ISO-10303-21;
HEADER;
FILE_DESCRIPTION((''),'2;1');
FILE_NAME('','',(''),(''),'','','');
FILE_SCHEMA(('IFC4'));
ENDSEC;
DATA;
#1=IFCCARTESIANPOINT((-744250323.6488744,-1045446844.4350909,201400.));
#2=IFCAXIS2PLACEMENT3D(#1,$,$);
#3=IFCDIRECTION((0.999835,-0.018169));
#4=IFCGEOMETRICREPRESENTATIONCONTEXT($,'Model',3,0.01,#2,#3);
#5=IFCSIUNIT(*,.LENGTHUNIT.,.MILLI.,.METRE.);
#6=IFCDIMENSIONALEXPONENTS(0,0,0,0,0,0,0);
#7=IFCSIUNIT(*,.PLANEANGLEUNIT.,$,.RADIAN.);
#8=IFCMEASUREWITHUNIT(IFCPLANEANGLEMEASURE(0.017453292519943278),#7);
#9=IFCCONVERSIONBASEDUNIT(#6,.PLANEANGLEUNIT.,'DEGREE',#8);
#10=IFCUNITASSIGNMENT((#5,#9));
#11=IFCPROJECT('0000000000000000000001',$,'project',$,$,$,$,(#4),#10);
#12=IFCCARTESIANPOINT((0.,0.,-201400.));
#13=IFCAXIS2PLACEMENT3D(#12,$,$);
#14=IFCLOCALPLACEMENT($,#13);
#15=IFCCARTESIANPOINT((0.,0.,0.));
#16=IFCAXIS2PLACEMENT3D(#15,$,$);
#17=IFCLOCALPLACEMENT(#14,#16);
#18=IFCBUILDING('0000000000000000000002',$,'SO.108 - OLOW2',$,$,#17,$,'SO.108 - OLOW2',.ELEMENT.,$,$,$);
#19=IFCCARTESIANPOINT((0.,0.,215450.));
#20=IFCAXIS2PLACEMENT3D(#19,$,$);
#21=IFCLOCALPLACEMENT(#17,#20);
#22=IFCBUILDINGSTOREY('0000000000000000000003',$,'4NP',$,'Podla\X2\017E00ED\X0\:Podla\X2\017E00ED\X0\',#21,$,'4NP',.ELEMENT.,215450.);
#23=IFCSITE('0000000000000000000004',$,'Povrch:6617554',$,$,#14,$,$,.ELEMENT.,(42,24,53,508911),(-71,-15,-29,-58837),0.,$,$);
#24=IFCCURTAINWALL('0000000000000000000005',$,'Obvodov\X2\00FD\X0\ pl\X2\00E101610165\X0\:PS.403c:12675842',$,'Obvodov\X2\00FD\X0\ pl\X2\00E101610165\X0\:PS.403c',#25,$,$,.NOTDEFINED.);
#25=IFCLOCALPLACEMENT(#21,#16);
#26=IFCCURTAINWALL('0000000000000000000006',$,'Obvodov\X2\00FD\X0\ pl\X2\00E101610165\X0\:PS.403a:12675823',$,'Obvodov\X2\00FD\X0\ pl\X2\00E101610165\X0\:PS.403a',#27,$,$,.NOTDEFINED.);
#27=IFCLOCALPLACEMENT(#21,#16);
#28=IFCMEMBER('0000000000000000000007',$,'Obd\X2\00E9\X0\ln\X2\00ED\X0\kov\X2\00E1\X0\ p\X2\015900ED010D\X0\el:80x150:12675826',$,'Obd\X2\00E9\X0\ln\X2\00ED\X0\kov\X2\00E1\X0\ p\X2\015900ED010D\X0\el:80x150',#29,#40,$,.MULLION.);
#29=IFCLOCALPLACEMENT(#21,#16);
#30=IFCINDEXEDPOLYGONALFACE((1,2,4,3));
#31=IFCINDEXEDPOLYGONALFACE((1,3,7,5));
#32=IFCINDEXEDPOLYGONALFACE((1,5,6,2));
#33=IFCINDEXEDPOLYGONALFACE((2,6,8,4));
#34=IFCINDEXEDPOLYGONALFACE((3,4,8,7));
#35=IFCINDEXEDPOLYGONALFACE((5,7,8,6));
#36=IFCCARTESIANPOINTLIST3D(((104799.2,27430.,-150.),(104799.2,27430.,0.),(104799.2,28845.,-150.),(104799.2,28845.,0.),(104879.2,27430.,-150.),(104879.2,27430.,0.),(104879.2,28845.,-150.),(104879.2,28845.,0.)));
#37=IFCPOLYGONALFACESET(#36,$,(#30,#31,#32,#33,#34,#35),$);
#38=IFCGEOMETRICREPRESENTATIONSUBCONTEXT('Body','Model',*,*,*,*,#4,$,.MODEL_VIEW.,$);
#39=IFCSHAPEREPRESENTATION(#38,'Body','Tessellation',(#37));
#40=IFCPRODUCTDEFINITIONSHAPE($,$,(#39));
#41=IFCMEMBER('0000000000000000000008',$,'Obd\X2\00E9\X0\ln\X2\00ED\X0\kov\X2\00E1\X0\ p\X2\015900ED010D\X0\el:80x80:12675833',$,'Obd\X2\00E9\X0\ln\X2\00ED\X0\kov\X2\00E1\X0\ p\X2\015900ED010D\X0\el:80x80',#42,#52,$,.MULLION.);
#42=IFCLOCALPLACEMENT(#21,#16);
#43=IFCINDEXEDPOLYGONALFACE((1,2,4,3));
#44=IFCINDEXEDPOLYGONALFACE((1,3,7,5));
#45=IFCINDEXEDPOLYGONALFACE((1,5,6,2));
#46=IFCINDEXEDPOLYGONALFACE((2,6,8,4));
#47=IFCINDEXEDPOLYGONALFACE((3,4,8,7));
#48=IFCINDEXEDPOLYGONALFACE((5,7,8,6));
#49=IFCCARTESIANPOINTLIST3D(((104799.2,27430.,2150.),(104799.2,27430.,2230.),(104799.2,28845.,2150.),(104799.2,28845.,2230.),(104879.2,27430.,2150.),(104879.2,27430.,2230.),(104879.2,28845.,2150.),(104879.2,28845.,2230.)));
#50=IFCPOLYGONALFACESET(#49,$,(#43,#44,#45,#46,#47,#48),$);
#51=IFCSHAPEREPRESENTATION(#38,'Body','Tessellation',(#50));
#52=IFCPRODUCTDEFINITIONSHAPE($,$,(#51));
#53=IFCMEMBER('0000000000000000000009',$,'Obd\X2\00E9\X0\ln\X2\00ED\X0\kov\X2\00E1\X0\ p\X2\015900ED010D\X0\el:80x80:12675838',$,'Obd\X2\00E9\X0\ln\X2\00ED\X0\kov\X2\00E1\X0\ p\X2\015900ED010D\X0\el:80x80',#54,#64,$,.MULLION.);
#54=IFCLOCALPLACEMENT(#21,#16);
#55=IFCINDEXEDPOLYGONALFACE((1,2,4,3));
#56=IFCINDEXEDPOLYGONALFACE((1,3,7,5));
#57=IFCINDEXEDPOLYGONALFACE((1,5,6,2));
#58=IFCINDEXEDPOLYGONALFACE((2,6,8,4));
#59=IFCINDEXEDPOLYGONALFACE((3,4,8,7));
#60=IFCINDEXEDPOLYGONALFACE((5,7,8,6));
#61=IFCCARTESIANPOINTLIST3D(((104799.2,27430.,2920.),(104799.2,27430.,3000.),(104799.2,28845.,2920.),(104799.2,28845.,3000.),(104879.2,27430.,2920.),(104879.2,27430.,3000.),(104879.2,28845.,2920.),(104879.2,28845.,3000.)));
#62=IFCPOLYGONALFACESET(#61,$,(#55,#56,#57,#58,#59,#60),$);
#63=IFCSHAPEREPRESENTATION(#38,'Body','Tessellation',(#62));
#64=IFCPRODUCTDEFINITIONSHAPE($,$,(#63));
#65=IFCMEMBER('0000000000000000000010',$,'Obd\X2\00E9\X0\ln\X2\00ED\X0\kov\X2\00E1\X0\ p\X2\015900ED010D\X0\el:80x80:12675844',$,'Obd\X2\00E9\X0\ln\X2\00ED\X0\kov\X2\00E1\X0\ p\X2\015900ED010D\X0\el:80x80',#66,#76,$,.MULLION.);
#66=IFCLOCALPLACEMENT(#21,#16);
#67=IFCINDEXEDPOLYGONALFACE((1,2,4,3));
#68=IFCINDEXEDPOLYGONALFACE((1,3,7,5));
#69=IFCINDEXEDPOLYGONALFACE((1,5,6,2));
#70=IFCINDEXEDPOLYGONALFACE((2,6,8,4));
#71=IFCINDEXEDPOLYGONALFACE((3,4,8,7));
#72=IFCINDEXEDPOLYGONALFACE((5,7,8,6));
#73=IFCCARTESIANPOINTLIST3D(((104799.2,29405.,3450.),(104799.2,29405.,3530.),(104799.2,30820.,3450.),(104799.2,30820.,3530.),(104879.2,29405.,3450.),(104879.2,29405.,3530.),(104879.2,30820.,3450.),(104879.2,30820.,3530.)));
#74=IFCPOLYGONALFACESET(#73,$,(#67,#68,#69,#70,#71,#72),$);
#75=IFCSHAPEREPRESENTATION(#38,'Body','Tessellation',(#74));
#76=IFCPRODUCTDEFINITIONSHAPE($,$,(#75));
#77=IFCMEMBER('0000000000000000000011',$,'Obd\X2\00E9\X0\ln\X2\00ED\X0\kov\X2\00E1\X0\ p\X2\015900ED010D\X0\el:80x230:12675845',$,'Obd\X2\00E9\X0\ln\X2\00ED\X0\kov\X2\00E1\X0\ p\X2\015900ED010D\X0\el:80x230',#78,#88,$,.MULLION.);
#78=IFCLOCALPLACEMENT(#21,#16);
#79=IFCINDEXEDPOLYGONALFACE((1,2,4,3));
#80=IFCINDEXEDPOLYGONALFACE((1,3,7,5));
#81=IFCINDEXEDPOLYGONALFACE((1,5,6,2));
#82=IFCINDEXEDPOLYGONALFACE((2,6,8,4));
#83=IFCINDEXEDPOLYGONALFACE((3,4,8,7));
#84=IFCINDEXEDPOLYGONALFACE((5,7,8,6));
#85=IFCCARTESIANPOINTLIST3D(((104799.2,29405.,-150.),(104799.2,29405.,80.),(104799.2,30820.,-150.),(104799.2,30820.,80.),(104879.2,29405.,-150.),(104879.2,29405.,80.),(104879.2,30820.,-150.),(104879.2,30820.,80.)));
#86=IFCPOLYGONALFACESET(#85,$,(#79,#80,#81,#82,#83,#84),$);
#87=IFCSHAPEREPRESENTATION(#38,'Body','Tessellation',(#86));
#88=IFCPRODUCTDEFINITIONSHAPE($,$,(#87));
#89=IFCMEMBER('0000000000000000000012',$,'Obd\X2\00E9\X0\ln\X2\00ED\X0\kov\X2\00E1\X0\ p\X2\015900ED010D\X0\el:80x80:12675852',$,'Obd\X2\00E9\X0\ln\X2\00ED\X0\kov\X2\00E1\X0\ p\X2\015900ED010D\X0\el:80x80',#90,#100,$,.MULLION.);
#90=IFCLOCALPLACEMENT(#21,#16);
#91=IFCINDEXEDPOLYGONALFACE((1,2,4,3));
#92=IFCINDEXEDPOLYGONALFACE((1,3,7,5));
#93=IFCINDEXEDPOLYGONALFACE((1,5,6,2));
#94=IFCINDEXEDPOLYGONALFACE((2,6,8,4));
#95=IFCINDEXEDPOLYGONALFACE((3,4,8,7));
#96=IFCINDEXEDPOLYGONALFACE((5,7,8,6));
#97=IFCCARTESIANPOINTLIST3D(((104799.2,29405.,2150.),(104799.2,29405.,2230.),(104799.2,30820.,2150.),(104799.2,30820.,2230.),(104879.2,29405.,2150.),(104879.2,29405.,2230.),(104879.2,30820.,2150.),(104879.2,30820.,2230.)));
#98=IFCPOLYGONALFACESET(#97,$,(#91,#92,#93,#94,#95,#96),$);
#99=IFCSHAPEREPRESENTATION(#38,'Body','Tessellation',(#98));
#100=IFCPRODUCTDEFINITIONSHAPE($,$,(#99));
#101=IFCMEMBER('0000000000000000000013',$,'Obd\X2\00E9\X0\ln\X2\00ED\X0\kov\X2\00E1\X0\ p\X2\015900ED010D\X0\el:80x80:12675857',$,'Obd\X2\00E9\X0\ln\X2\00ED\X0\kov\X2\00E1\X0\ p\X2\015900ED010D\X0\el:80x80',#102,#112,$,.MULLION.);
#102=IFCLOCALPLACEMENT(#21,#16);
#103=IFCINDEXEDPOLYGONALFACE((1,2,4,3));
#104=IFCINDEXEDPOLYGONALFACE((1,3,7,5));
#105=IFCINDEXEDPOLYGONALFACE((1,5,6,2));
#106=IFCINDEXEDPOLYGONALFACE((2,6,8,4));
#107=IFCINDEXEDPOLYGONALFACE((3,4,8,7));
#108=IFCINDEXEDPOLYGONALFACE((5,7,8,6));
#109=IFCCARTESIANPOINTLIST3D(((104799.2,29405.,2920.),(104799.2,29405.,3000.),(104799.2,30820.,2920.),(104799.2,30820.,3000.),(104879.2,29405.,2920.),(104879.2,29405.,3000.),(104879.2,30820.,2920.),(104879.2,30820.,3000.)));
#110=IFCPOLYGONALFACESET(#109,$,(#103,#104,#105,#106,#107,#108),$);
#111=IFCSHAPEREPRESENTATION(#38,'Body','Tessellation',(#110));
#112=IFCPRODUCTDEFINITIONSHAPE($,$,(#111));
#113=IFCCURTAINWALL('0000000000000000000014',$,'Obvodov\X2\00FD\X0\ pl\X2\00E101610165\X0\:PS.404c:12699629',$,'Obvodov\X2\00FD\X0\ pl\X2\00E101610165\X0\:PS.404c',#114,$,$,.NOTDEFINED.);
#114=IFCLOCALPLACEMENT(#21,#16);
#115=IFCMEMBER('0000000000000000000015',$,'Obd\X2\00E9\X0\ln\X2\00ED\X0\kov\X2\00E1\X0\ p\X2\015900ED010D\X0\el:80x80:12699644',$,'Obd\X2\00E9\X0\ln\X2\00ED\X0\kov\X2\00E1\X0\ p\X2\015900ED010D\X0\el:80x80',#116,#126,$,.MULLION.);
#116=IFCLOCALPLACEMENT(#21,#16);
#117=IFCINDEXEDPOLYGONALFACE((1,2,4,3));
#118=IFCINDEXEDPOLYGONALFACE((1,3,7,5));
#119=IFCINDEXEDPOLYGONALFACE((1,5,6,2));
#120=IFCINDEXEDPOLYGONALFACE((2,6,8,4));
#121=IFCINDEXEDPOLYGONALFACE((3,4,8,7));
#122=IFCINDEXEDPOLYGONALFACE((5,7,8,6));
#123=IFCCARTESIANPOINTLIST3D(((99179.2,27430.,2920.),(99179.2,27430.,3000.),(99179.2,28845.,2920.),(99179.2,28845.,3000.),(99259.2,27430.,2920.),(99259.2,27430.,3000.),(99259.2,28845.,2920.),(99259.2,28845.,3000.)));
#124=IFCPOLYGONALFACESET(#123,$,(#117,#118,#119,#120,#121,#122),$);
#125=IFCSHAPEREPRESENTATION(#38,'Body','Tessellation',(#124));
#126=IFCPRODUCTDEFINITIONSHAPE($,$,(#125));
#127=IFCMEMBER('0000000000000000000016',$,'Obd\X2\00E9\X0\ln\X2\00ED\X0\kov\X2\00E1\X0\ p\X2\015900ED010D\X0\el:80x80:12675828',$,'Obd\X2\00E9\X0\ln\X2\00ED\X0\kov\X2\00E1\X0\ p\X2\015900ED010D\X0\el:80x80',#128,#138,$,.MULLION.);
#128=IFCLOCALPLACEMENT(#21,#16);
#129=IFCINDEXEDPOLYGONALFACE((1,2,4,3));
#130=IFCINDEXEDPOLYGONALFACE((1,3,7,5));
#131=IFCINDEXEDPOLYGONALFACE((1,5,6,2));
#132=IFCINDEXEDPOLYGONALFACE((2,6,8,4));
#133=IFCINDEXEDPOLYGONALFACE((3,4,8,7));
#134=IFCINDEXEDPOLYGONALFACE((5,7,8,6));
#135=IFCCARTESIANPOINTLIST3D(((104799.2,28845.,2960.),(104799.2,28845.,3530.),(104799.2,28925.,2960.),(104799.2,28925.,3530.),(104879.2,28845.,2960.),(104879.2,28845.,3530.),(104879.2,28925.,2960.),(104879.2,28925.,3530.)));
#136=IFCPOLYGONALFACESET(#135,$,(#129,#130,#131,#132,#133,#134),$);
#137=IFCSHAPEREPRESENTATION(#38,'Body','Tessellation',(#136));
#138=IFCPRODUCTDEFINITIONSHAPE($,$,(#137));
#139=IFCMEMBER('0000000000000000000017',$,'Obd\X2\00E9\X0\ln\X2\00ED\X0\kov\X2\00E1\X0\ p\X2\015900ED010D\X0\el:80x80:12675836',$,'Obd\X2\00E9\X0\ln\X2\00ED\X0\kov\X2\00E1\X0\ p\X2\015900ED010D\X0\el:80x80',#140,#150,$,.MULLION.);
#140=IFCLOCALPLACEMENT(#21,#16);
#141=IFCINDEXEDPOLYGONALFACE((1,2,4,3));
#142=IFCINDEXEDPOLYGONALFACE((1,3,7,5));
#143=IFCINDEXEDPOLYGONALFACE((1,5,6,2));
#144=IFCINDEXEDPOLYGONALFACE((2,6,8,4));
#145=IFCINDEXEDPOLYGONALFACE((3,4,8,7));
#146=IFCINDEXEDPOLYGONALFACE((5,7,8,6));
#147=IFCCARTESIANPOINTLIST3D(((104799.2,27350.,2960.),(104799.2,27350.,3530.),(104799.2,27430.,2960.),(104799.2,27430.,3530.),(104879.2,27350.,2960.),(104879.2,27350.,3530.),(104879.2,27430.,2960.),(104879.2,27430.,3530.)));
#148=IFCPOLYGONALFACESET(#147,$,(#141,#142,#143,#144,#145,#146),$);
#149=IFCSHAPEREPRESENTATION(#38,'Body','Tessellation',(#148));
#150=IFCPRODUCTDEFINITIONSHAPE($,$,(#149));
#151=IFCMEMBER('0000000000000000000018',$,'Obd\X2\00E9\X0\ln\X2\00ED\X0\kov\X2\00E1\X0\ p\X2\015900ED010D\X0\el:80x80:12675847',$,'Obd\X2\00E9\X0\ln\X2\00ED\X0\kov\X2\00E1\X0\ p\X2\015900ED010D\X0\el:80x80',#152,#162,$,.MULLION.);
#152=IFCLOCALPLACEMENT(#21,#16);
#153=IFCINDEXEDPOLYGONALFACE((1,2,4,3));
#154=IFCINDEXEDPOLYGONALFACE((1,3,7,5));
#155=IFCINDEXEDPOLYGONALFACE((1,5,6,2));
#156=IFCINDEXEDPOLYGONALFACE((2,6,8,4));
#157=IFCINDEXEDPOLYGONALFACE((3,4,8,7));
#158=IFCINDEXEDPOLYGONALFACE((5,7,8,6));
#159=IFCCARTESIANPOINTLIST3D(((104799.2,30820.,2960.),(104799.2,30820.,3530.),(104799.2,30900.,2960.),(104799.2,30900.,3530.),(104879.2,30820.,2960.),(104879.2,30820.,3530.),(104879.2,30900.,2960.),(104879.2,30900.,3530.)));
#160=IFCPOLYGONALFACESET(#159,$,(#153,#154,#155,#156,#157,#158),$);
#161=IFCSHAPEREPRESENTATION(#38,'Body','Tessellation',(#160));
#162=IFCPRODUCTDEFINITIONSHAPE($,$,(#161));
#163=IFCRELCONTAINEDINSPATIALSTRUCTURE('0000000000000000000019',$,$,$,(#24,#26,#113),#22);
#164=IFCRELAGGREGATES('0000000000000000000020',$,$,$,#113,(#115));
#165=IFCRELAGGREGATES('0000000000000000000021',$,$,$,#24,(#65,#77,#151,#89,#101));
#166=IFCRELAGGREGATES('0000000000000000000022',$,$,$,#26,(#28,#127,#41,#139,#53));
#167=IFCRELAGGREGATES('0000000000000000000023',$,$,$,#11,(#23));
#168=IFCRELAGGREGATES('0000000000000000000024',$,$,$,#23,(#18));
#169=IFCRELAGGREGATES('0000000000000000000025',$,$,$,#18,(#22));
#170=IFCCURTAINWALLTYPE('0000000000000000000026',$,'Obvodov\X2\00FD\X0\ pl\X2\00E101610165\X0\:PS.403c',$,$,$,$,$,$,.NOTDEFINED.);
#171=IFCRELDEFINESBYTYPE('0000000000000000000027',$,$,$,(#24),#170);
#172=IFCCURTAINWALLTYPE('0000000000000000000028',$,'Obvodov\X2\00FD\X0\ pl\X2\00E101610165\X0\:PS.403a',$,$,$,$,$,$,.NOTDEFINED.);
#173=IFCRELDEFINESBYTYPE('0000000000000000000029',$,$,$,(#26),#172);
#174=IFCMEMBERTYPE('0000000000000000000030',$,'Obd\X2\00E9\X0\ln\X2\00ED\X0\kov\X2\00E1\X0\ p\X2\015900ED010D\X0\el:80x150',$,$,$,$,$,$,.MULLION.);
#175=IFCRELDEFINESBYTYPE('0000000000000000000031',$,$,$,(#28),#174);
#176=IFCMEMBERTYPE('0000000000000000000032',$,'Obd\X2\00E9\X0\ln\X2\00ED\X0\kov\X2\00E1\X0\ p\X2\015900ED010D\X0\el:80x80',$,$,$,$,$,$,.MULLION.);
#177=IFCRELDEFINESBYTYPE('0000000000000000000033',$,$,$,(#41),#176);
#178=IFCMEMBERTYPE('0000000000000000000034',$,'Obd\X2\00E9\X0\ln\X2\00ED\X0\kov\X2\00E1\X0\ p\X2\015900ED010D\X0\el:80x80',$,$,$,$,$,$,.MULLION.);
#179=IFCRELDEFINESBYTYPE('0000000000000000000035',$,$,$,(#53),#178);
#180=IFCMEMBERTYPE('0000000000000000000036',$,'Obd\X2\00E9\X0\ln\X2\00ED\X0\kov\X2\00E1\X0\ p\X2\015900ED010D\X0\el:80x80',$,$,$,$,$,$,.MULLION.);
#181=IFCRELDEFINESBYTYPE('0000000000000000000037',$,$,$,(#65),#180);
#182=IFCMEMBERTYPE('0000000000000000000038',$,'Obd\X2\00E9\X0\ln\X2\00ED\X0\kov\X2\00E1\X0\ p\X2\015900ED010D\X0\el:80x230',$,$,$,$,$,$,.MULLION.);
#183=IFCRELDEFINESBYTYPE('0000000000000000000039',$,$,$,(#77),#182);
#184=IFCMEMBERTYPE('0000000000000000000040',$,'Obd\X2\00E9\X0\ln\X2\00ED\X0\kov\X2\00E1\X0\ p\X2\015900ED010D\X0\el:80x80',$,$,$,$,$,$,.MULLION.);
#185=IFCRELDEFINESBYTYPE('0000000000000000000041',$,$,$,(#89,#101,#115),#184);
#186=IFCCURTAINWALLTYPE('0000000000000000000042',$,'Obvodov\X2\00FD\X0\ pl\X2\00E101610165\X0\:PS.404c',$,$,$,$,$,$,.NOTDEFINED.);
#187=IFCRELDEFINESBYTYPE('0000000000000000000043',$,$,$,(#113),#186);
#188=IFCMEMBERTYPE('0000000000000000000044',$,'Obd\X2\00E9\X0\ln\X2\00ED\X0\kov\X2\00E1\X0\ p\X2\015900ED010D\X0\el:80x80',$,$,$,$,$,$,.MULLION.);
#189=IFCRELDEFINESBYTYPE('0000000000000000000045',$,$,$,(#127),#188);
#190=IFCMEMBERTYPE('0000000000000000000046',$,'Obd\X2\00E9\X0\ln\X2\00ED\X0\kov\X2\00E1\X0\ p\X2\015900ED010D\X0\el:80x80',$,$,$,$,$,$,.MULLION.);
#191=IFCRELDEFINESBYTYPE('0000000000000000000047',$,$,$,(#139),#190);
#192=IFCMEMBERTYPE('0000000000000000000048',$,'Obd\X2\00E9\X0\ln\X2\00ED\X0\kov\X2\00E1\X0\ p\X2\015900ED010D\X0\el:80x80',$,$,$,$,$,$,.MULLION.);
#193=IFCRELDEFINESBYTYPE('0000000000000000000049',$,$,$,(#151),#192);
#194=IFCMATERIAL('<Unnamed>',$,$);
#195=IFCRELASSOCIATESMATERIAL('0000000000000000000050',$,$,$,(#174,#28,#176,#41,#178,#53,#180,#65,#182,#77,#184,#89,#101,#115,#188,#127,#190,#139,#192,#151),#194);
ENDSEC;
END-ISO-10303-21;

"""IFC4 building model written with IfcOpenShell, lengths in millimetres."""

from ifc_helpers import new_model, entity, si_unit, converted_unit, direction, frame, origin, place, context, subcontext, project, spatial, indexed_curve, outline, extrude, source, transform, mapped, material, type_object, type_shapes, element, aggregate, save


model = new_model("IFC4")

# Units and contexts
model_context = context("Model", 3, precision=0.01, world=frame((-744250323.6488744, -1045446844.4350909, 201400.0)), true_north=direction((0.999835, -0.018169)))
body_context = subcontext(model_context, "Body", "Model", "MODEL_VIEW")
ifc_project = project(units=[si_unit("LENGTHUNIT", "METRE", prefix="MILLI"), converted_unit("PLANEANGLEUNIT", "DEGREE", entity("IfcPlaneAngleMeasure", 0.017453292519943278), si_unit("PLANEANGLEUNIT", "RADIAN"), dimensions=[0, 0, 0, 0, 0, 0, 0])], contexts=[model_context])

# Site, building, storey
site_placement = place(None, frame((0.0, 0.0, -201400.0)))
site = spatial("IfcSite", under=ifc_project, at=site_placement, Name="Povrch:6617554", CompositionType="ELEMENT", RefLatitude=(42, 24, 53, 508911), RefLongitude=(-71, -15, -29, -58837), RefElevation=0.0)
building_placement = place(site_placement, origin())
building = spatial("IfcBuilding", under=site, at=building_placement, Name="SO.108 - OLOW2", LongName="SO.108 - OLOW2", CompositionType="ELEMENT")
storey_placement = place(building_placement, frame((0.0, 0.0, 215450.0)))
storey = spatial("IfcBuildingStorey", under=building, at=storey_placement, Name="4NP", ObjectType="Podlaží:Podlaží", LongName="4NP", CompositionType="ELEMENT", Elevation=215450.0)

# Curtain wall
curtain_wall_type_1 = type_object("IfcCurtainWallType", Name="Obvodový plášť:PS.403c", PredefinedType="NOTDEFINED")
curtain_wall_1_placement = place(storey_placement, frame((0.0, 0.0, -215450.0)))
curtain_wall_1 = element("IfcCurtainWall", 1, at=curtain_wall_1_placement, inside=storey, type_object=curtain_wall_type_1, Name="Obvodový plášť:PS.403c:12675842", ObjectType="Obvodový plášť:PS.403c", PredefinedType="NOTDEFINED")
ifc_material_1 = material(Name="<Unnamed>")

# Curtain wall, members
curtain_wall_type_2 = type_object("IfcCurtainWallType", Name="Obvodový plášť:PS.403a", PredefinedType="NOTDEFINED")
curtain_wall_2_placement = place(storey_placement, frame((0.0, 0.0, -215450.0)))
curtain_wall_2 = element("IfcCurtainWall", 2, at=curtain_wall_2_placement, inside=storey, type_object=curtain_wall_type_2, Name="Obvodový plášť:PS.403a:12675823", ObjectType="Obvodový plášť:PS.403a", PredefinedType="NOTDEFINED")
member_type_1 = type_object("IfcMemberType", Name="Obdélníková příčel:80x150", PredefinedType="MULLION", material=ifc_material_1)
shared_shape_1 = source(origin(), body_context, "Body", "SweptSolid", [
    extrude(outline(indexed_curve([(-75.0, -40.0), (75.0, -40.0), (75.0, 40.0), (-75.0, 40.0), (-75.0, -40.0)], self_intersect=False)), frame((-75.0, 0.0, -1415.0), z_axis=(0.0, 0.0, 1.0), x_axis=(-1.0, 0.0, 0.0)), (0.0, 0.0, 1.0), 1415.0),
])
type_shapes(member_type_1, [shared_shape_1])
member_1_placement = place(curtain_wall_2_placement, frame((104839.2, 28845.0, 215300.0), z_axis=(0.0, 1.0, 0.0), x_axis=(0.0, 0.0, -1.0)))
member_1 = element("IfcMember", 3, at=member_1_placement, type_object=member_type_1, material=ifc_material_1, Name="Obdélníková příčel:80x150:12675826", ObjectType="Obdélníková příčel:80x150", PredefinedType="MULLION", context=body_context, shape_type="MappedRepresentation", body=[
    mapped(shared_shape_1, transform((0.0, 0.0, 0.0), scale=1.0)),
])
member_type_2 = type_object("IfcMemberType", Name="Obdélníková příčel:80x80", PredefinedType="MULLION", material=ifc_material_1)
shared_shape_2 = source(origin(), body_context, "Body", "SweptSolid", [
    extrude(outline(indexed_curve([(-40.0, -40.0), (40.0, -40.0), (40.0, 40.0), (-40.0, 40.0), (-40.0, -40.0)], self_intersect=False)), frame((0.0, 0.0, -1415.0), z_axis=(0.0, 0.0, 1.0), x_axis=(-1.0, 0.0, 0.0)), (0.0, 0.0, 1.0), 1415.0),
])
type_shapes(member_type_2, [shared_shape_2])
member_2_placement = place(curtain_wall_2_placement, frame((104839.2, 27430.0, 217640.0), z_axis=(0.0, -1.0, 0.0), x_axis=(0.0, 0.0, 1.0)))
member_2 = element("IfcMember", 4, at=member_2_placement, type_object=member_type_2, material=ifc_material_1, Name="Obdélníková příčel:80x80:12675833", ObjectType="Obdélníková příčel:80x80", PredefinedType="MULLION", context=body_context, shape_type="MappedRepresentation", body=[
    mapped(shared_shape_2, transform((0.0, 0.0, 0.0), scale=1.0)),
])
member_type_3 = type_object("IfcMemberType", Name="Obdélníková příčel:80x80", PredefinedType="MULLION", material=ifc_material_1)
shared_shape_3 = source(origin(), body_context, "Body", "SweptSolid", [
    extrude(outline(indexed_curve([(-40.0, -40.0), (40.0, -40.0), (40.0, 40.0), (-40.0, 40.0), (-40.0, -40.0)], self_intersect=False)), frame((0.0, 0.0, -1415.0), z_axis=(0.0, 0.0, 1.0), x_axis=(-1.0, 0.0, 0.0)), (0.0, 0.0, 1.0), 1415.0),
])
type_shapes(member_type_3, [shared_shape_3])
member_3_placement = place(curtain_wall_2_placement, frame((104839.2, 27430.0, 218410.0), z_axis=(0.0, -1.0, 0.0), x_axis=(0.0, 0.0, 1.0)))
member_3 = element("IfcMember", 5, at=member_3_placement, type_object=member_type_3, material=ifc_material_1, Name="Obdélníková příčel:80x80:12675838", ObjectType="Obdélníková příčel:80x80", PredefinedType="MULLION", context=body_context, shape_type="MappedRepresentation", body=[
    mapped(shared_shape_3, transform((0.0, 0.0, 0.0), scale=1.0)),
])

# Members
member_type_4 = type_object("IfcMemberType", Name="Obdélníková příčel:80x80", PredefinedType="MULLION", material=ifc_material_1)
shared_shape_4 = source(origin(), body_context, "Body", "SweptSolid", [
    extrude(outline(indexed_curve([(-40.0, -40.0), (40.0, -40.0), (40.0, 40.0), (-40.0, 40.0), (-40.0, -40.0)], self_intersect=False)), frame((-40.0, 0.0, -1415.0), z_axis=(0.0, 0.0, 1.0), x_axis=(-1.0, 0.0, 0.0)), (0.0, 0.0, 1.0), 1415.0),
])
type_shapes(member_type_4, [shared_shape_4])
member_4_placement = place(curtain_wall_1_placement, frame((104839.2, 29405.0, 218980.0), z_axis=(0.0, -1.0, 0.0), x_axis=(0.0, 0.0, 1.0)))
member_4 = element("IfcMember", 6, at=member_4_placement, type_object=member_type_4, material=ifc_material_1, Name="Obdélníková příčel:80x80:12675844", ObjectType="Obdélníková příčel:80x80", PredefinedType="MULLION", context=body_context, shape_type="MappedRepresentation", body=[
    mapped(shared_shape_4, transform((0.0, 0.0, 0.0), scale=1.0)),
])
member_type_5 = type_object("IfcMemberType", Name="Obdélníková příčel:80x230", PredefinedType="MULLION", material=ifc_material_1)
shared_shape_5 = source(origin(), body_context, "Body", "SweptSolid", [
    extrude(outline(indexed_curve([(-115.0, -40.0), (115.0, -40.0), (115.0, 40.0), (-115.0, 40.0), (-115.0, -40.0)], self_intersect=False)), frame((-115.0, 0.0, -1415.0), z_axis=(0.0, 0.0, 1.0), x_axis=(-1.0, 0.0, 0.0)), (0.0, 0.0, 1.0), 1415.0),
])
type_shapes(member_type_5, [shared_shape_5])
member_5_placement = place(curtain_wall_1_placement, frame((104839.2, 30820.0, 215300.0), z_axis=(0.0, 1.0, 0.0), x_axis=(0.0, 0.0, -1.0)))
member_5 = element("IfcMember", 7, at=member_5_placement, type_object=member_type_5, material=ifc_material_1, Name="Obdélníková příčel:80x230:12675845", ObjectType="Obdélníková příčel:80x230", PredefinedType="MULLION", context=body_context, shape_type="MappedRepresentation", body=[
    mapped(shared_shape_5, transform((0.0, 0.0, 0.0), scale=1.0)),
])
member_type_6 = type_object("IfcMemberType", Name="Obdélníková příčel:80x80", PredefinedType="MULLION", material=ifc_material_1)
shared_shape_6 = source(origin(), body_context, "Body", "SweptSolid", [
    extrude(outline(indexed_curve([(-40.0, -40.0), (40.0, -40.0), (40.0, 40.0), (-40.0, 40.0), (-40.0, -40.0)], self_intersect=False)), frame((0.0, 0.0, -1415.0), z_axis=(0.0, 0.0, 1.0), x_axis=(-1.0, 0.0, 0.0)), (0.0, 0.0, 1.0), 1415.0),
])
type_shapes(member_type_6, [shared_shape_6])
member_6_placement = place(curtain_wall_1_placement, frame((104839.2, 29405.0, 217640.0), z_axis=(0.0, -1.0, 0.0), x_axis=(0.0, 0.0, 1.0)))
member_6 = element("IfcMember", 8, at=member_6_placement, type_object=member_type_6, material=ifc_material_1, Name="Obdélníková příčel:80x80:12675852", ObjectType="Obdélníková příčel:80x80", PredefinedType="MULLION", context=body_context, shape_type="MappedRepresentation", body=[
    mapped(shared_shape_6, transform((0.0, 0.0, 0.0), scale=1.0)),
])
member_7_placement = place(curtain_wall_1_placement, frame((104839.2, 29405.0, 218410.0), z_axis=(0.0, -1.0, 0.0), x_axis=(0.0, 0.0, 1.0)))
member_7 = element("IfcMember", 9, at=member_7_placement, type_object=member_type_6, material=ifc_material_1, Name="Obdélníková příčel:80x80:12675857", ObjectType="Obdélníková příčel:80x80", PredefinedType="MULLION", context=body_context, shape_type="MappedRepresentation", body=[
    mapped(shared_shape_6, transform((0.0, 0.0, 0.0), scale=1.0)),
])

# Curtain wall, member
curtain_wall_type_3 = type_object("IfcCurtainWallType", Name="Obvodový plášť:PS.404c", PredefinedType="NOTDEFINED")
curtain_wall_3_placement = place(storey_placement, frame((0.0, 0.0, -215450.0)))
curtain_wall_3 = element("IfcCurtainWall", 10, at=curtain_wall_3_placement, inside=storey, type_object=curtain_wall_type_3, Name="Obvodový plášť:PS.404c:12699629", ObjectType="Obvodový plášť:PS.404c", PredefinedType="NOTDEFINED")
member_8_placement = place(curtain_wall_3_placement, frame((99219.2, 27430.0, 218410.0), z_axis=(0.0, -1.0, 0.0), x_axis=(0.0, 0.0, 1.0)))
member_8 = element("IfcMember", 11, at=member_8_placement, type_object=member_type_6, material=ifc_material_1, Name="Obdélníková příčel:80x80:12699644", ObjectType="Obdélníková příčel:80x80", PredefinedType="MULLION", context=body_context, shape_type="MappedRepresentation", body=[
    mapped(shared_shape_6, transform((0.0, 0.0, 0.0), scale=1.0)),
])
aggregate(curtain_wall_3, [member_8])

# Members
member_type_7 = type_object("IfcMemberType", Name="Obdélníková příčel:80x80", PredefinedType="MULLION", material=ifc_material_1)
shared_shape_7 = source(origin(), body_context, "Body", "SweptSolid", [
    extrude(outline(indexed_curve([(-40.0, -40.0), (40.0, -40.0), (40.0, 40.0), (-40.0, 40.0), (-40.0, -40.0)], self_intersect=False)), frame((-40.0, 0.0, -570.0), z_axis=(0.0, 0.0, 1.0), x_axis=(-1.0, 0.0, 0.0)), (0.0, 0.0, 1.0), 570.0),
])
type_shapes(member_type_7, [shared_shape_7])
member_9_placement = place(curtain_wall_2_placement, frame((104839.2, 28925.0, 218980.0), z_axis=(0.0, 0.0, 1.0), x_axis=(0.0, 1.0, 0.0)))
member_9 = element("IfcMember", 12, at=member_9_placement, type_object=member_type_7, material=ifc_material_1, Name="Obdélníková příčel:80x80:12675828", ObjectType="Obdélníková příčel:80x80", PredefinedType="MULLION", context=body_context, shape_type="MappedRepresentation", body=[
    mapped(shared_shape_7, transform((0.0, 0.0, 0.0), scale=1.0)),
])
member_type_8 = type_object("IfcMemberType", Name="Obdélníková příčel:80x80", PredefinedType="MULLION", material=ifc_material_1)
shared_shape_8 = source(origin(), body_context, "Body", "SweptSolid", [
    extrude(outline(indexed_curve([(-40.0, -40.0), (40.0, -40.0), (40.0, 40.0), (-40.0, 40.0), (-40.0, -40.0)], self_intersect=False)), frame((-40.0, 0.0, -570.0), z_axis=(0.0, 0.0, 1.0), x_axis=(-1.0, 0.0, 0.0)), (0.0, 0.0, 1.0), 570.0),
])
type_shapes(member_type_8, [shared_shape_8])
member_10_placement = place(curtain_wall_2_placement, frame((104839.2, 27350.0, 218410.0), z_axis=(0.0, 0.0, -1.0), x_axis=(0.0, -1.0, 0.0)))
member_10 = element("IfcMember", 13, at=member_10_placement, type_object=member_type_8, material=ifc_material_1, Name="Obdélníková příčel:80x80:12675836", ObjectType="Obdélníková příčel:80x80", PredefinedType="MULLION", context=body_context, shape_type="MappedRepresentation", body=[
    mapped(shared_shape_8, transform((0.0, 0.0, 0.0), scale=1.0)),
])
member_type_9 = type_object("IfcMemberType", Name="Obdélníková příčel:80x80", PredefinedType="MULLION", material=ifc_material_1)
shared_shape_9 = source(origin(), body_context, "Body", "SweptSolid", [
    extrude(outline(indexed_curve([(-40.0, -40.0), (40.0, -40.0), (40.0, 40.0), (-40.0, 40.0), (-40.0, -40.0)], self_intersect=False)), frame((-40.0, 0.0, -570.0), z_axis=(0.0, 0.0, 1.0), x_axis=(-1.0, 0.0, 0.0)), (0.0, 0.0, 1.0), 570.0),
])
type_shapes(member_type_9, [shared_shape_9])
member_11_placement = place(curtain_wall_1_placement, frame((104839.2, 30900.0, 218980.0), z_axis=(0.0, 0.0, 1.0), x_axis=(0.0, 1.0, 0.0)))
member_11 = element("IfcMember", 14, at=member_11_placement, type_object=member_type_9, material=ifc_material_1, Name="Obdélníková příčel:80x80:12675847", ObjectType="Obdélníková příčel:80x80", PredefinedType="MULLION", context=body_context, shape_type="MappedRepresentation", body=[
    mapped(shared_shape_9, transform((0.0, 0.0, 0.0), scale=1.0)),
])

aggregate(curtain_wall_1, [member_4, member_5, member_11, member_6, member_7])

aggregate(curtain_wall_2, [member_1, member_9, member_2, member_10, member_3])

save(model, "model.ifc")
